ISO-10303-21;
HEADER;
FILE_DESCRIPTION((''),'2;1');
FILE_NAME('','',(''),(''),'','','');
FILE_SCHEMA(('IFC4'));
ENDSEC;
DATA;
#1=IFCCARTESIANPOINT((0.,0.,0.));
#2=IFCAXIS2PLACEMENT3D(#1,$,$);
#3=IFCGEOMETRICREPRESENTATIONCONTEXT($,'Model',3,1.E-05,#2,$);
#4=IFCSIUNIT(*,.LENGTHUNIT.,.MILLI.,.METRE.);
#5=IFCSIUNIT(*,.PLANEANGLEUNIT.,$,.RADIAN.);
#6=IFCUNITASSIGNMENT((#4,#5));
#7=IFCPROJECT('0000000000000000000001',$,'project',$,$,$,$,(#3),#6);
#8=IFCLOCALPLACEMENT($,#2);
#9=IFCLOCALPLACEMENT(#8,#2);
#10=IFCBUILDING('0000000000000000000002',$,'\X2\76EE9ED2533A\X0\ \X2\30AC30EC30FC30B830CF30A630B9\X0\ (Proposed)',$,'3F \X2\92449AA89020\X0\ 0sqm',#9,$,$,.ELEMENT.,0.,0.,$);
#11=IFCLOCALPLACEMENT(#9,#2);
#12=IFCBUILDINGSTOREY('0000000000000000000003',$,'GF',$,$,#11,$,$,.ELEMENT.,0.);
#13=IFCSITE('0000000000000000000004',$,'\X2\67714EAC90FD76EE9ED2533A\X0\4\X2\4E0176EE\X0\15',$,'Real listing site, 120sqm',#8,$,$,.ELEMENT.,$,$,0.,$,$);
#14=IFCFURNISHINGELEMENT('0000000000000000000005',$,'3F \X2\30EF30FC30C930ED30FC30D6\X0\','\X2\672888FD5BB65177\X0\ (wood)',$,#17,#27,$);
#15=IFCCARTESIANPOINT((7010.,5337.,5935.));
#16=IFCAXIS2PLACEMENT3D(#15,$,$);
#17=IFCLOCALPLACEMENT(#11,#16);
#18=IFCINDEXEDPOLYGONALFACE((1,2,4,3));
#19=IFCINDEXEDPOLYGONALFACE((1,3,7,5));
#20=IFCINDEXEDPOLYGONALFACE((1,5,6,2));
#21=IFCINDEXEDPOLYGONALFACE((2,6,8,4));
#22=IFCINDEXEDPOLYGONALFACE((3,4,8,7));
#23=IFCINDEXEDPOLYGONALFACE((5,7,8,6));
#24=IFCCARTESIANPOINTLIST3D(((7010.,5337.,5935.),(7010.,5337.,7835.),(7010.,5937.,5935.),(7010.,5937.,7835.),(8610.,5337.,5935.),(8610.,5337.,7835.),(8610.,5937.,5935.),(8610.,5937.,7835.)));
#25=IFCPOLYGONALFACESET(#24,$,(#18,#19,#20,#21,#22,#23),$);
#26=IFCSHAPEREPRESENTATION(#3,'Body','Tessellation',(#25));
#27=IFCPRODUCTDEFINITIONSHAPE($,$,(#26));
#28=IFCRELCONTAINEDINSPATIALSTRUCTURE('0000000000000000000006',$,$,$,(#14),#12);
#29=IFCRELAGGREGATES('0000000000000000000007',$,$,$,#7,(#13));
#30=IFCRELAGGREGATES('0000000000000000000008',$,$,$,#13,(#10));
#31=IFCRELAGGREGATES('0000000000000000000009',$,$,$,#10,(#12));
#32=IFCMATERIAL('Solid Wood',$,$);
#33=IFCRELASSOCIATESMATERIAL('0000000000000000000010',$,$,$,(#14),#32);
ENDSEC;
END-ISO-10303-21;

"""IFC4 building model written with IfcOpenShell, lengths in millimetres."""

from ifc_helpers import new_model, si_unit, frame, frame_2d, origin, place, context, project, spatial, rectangle, extrude, material, element, save


model = new_model("IFC4")

# Units and contexts
model_context = context("Model", 3, precision=1e-05, world=origin())
ifc_project = project(units=[si_unit("LENGTHUNIT", "METRE", prefix="MILLI"), si_unit("PLANEANGLEUNIT", "RADIAN")], contexts=[model_context])

# Site, building, storey
site_placement = place(None, origin())
site = spatial("IfcSite", under=ifc_project, at=site_placement, Name="東京都目黒区4丁目15", ObjectType="Real listing site, 120sqm", CompositionType="ELEMENT", RefElevation=0.0)
building_placement = place(site_placement, origin())
building = spatial("IfcBuilding", under=site, at=building_placement, Name="目黒区 ガレージハウス (Proposed)", ObjectType="3F 鉄骨造 0sqm", CompositionType="ELEMENT", ElevationOfRefHeight=0.0, ElevationOfTerrain=0.0)
storey_placement = place(building_placement, origin())
storey = spatial("IfcBuildingStorey", under=building, at=storey_placement, Name="GF", CompositionType="ELEMENT", Elevation=0.0)

# Shared definitions
ifc_material_1 = material(Name="Solid Wood")

# Furnishing element
furnishing_1_placement = place(storey_placement, frame((7010.0, 5337.0, 5935.0)))
element("IfcFurnishingElement", 1, at=furnishing_1_placement, inside=storey, material=ifc_material_1, Name="3F ワードローブ", Description="木製家具 (wood)", context=model_context, shape_type="SweptSolid", body=[
    extrude(rectangle(XDim=1600.0, YDim=600.0, at=frame_2d((800.0, 300.0))), frame((7010.0, 5337.0, 5935.0)), (0.0, 0.0, 1.0), 1900.0),
])

save(model, "model.ifc")
